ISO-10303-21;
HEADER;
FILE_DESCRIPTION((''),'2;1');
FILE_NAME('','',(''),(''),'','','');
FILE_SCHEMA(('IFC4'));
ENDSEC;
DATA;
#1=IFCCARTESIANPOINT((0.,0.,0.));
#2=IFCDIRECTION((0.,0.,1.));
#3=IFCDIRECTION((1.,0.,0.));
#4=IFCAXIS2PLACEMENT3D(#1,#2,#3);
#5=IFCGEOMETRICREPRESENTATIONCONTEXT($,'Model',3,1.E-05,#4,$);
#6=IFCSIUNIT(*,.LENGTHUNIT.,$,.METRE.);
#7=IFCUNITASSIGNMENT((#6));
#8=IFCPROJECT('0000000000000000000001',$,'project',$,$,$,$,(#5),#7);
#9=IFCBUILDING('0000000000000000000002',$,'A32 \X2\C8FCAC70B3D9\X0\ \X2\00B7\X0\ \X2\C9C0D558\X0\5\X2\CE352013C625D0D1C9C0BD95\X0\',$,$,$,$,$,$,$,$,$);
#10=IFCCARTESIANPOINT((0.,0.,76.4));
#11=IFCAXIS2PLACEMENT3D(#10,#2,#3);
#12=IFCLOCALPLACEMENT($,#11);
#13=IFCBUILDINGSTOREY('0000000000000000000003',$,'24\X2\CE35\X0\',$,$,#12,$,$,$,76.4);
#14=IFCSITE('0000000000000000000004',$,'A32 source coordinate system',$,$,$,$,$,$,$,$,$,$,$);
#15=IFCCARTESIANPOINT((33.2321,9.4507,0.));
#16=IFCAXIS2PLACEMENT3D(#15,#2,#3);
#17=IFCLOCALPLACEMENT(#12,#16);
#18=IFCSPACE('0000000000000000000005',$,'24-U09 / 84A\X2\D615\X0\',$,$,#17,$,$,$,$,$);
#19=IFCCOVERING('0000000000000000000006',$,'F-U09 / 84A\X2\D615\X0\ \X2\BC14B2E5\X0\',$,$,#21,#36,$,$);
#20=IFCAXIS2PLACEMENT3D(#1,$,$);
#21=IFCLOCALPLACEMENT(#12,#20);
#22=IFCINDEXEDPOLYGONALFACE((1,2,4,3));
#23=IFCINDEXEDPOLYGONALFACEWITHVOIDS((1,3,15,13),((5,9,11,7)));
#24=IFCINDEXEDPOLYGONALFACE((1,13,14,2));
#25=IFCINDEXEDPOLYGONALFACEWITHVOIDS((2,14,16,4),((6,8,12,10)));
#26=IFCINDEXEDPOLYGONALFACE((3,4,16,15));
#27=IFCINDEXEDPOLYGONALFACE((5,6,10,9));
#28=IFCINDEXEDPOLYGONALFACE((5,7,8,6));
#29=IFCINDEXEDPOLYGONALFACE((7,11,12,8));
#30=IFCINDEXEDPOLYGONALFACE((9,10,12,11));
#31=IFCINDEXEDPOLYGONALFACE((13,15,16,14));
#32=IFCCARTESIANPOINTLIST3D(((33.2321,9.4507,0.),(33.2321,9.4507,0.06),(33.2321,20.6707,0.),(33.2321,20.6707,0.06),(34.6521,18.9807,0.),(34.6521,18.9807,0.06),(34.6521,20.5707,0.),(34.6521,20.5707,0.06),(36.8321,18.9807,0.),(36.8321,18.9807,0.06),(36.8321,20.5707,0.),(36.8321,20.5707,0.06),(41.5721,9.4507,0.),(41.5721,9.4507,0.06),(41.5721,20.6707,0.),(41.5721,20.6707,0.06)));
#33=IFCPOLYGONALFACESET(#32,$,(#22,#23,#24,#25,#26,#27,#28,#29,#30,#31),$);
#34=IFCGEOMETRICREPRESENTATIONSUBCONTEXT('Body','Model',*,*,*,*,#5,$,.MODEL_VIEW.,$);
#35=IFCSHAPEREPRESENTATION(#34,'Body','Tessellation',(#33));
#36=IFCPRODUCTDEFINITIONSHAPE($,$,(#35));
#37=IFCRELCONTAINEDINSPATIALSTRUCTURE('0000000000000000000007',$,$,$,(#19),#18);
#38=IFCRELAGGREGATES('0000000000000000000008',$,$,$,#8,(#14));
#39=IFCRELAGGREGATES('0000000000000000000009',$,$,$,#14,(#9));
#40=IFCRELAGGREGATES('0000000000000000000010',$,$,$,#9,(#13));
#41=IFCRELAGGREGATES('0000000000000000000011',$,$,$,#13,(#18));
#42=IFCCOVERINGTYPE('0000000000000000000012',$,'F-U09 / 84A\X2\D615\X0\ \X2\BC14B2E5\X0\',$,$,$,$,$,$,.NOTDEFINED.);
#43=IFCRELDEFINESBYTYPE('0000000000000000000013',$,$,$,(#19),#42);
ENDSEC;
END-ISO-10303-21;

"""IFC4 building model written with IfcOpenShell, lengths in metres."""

from ifc_helpers import new_model, si_unit, frame, origin, origin_with_axes, place, context, subcontext, project, spatial, polyline, outline, extrude, source, transform, mapped, type_object, type_shapes, element, save


model = new_model("IFC4")

# Units and contexts
model_context = context("Model", 3, precision=1e-05, world=origin_with_axes())
body_context = subcontext(model_context, "Body", "Model", "MODEL_VIEW")
ifc_project = project(units=[si_unit("LENGTHUNIT", "METRE")], contexts=[model_context])

# Site, building, storey, space
site = spatial("IfcSite", under=ifc_project, Name="A32 source coordinate system")
building = spatial("IfcBuilding", under=site, Name="A32 주거동 · 지하5층–옥탑지붕")
storey_placement = place(None, frame((0.0, 0.0, 76.4), z_axis=(0.0, 0.0, 1.0), x_axis=(1.0, 0.0, 0.0)))
storey = spatial("IfcBuildingStorey", under=building, at=storey_placement, Name="24층", Elevation=76.4)
space_placement = place(storey_placement, frame((33.2321, 9.4507, 0.0), z_axis=(0.0, 0.0, 1.0), x_axis=(1.0, 0.0, 0.0)))
space = spatial("IfcSpace", under=storey, at=space_placement, Name="24-U09 / 84A형")

# Covering
covering_type_1 = type_object("IfcCoveringType", Name="F-U09 / 84A형 바닥", PredefinedType="NOTDEFINED")
shared_shape_1 = source(origin(), body_context, "Body", "SweptSolid", [
    extrude(outline(polyline([(0.0, 0.0), (0.0, 11.22), (8.34, 11.22), (8.34, 0.0), (0.0, 0.0)]), holes=[polyline([(1.42, 11.12), (1.42, 9.53), (3.6, 9.53), (3.6, 11.12), (1.42, 11.12)])]), origin(), (0.0, 0.0, 1.0), 0.06),
])
type_shapes(covering_type_1, [shared_shape_1])
covering_1_placement = place(space_placement, origin_with_axes())
element("IfcCovering", 1, at=covering_1_placement, inside=space, type_object=covering_type_1, Name="F-U09 / 84A형 바닥", context=body_context, shape_type="MappedRepresentation", body=[
    mapped(shared_shape_1, transform((0.0, 0.0, 0.0), scale=1.0)),
])

save(model, "model.ifc")
